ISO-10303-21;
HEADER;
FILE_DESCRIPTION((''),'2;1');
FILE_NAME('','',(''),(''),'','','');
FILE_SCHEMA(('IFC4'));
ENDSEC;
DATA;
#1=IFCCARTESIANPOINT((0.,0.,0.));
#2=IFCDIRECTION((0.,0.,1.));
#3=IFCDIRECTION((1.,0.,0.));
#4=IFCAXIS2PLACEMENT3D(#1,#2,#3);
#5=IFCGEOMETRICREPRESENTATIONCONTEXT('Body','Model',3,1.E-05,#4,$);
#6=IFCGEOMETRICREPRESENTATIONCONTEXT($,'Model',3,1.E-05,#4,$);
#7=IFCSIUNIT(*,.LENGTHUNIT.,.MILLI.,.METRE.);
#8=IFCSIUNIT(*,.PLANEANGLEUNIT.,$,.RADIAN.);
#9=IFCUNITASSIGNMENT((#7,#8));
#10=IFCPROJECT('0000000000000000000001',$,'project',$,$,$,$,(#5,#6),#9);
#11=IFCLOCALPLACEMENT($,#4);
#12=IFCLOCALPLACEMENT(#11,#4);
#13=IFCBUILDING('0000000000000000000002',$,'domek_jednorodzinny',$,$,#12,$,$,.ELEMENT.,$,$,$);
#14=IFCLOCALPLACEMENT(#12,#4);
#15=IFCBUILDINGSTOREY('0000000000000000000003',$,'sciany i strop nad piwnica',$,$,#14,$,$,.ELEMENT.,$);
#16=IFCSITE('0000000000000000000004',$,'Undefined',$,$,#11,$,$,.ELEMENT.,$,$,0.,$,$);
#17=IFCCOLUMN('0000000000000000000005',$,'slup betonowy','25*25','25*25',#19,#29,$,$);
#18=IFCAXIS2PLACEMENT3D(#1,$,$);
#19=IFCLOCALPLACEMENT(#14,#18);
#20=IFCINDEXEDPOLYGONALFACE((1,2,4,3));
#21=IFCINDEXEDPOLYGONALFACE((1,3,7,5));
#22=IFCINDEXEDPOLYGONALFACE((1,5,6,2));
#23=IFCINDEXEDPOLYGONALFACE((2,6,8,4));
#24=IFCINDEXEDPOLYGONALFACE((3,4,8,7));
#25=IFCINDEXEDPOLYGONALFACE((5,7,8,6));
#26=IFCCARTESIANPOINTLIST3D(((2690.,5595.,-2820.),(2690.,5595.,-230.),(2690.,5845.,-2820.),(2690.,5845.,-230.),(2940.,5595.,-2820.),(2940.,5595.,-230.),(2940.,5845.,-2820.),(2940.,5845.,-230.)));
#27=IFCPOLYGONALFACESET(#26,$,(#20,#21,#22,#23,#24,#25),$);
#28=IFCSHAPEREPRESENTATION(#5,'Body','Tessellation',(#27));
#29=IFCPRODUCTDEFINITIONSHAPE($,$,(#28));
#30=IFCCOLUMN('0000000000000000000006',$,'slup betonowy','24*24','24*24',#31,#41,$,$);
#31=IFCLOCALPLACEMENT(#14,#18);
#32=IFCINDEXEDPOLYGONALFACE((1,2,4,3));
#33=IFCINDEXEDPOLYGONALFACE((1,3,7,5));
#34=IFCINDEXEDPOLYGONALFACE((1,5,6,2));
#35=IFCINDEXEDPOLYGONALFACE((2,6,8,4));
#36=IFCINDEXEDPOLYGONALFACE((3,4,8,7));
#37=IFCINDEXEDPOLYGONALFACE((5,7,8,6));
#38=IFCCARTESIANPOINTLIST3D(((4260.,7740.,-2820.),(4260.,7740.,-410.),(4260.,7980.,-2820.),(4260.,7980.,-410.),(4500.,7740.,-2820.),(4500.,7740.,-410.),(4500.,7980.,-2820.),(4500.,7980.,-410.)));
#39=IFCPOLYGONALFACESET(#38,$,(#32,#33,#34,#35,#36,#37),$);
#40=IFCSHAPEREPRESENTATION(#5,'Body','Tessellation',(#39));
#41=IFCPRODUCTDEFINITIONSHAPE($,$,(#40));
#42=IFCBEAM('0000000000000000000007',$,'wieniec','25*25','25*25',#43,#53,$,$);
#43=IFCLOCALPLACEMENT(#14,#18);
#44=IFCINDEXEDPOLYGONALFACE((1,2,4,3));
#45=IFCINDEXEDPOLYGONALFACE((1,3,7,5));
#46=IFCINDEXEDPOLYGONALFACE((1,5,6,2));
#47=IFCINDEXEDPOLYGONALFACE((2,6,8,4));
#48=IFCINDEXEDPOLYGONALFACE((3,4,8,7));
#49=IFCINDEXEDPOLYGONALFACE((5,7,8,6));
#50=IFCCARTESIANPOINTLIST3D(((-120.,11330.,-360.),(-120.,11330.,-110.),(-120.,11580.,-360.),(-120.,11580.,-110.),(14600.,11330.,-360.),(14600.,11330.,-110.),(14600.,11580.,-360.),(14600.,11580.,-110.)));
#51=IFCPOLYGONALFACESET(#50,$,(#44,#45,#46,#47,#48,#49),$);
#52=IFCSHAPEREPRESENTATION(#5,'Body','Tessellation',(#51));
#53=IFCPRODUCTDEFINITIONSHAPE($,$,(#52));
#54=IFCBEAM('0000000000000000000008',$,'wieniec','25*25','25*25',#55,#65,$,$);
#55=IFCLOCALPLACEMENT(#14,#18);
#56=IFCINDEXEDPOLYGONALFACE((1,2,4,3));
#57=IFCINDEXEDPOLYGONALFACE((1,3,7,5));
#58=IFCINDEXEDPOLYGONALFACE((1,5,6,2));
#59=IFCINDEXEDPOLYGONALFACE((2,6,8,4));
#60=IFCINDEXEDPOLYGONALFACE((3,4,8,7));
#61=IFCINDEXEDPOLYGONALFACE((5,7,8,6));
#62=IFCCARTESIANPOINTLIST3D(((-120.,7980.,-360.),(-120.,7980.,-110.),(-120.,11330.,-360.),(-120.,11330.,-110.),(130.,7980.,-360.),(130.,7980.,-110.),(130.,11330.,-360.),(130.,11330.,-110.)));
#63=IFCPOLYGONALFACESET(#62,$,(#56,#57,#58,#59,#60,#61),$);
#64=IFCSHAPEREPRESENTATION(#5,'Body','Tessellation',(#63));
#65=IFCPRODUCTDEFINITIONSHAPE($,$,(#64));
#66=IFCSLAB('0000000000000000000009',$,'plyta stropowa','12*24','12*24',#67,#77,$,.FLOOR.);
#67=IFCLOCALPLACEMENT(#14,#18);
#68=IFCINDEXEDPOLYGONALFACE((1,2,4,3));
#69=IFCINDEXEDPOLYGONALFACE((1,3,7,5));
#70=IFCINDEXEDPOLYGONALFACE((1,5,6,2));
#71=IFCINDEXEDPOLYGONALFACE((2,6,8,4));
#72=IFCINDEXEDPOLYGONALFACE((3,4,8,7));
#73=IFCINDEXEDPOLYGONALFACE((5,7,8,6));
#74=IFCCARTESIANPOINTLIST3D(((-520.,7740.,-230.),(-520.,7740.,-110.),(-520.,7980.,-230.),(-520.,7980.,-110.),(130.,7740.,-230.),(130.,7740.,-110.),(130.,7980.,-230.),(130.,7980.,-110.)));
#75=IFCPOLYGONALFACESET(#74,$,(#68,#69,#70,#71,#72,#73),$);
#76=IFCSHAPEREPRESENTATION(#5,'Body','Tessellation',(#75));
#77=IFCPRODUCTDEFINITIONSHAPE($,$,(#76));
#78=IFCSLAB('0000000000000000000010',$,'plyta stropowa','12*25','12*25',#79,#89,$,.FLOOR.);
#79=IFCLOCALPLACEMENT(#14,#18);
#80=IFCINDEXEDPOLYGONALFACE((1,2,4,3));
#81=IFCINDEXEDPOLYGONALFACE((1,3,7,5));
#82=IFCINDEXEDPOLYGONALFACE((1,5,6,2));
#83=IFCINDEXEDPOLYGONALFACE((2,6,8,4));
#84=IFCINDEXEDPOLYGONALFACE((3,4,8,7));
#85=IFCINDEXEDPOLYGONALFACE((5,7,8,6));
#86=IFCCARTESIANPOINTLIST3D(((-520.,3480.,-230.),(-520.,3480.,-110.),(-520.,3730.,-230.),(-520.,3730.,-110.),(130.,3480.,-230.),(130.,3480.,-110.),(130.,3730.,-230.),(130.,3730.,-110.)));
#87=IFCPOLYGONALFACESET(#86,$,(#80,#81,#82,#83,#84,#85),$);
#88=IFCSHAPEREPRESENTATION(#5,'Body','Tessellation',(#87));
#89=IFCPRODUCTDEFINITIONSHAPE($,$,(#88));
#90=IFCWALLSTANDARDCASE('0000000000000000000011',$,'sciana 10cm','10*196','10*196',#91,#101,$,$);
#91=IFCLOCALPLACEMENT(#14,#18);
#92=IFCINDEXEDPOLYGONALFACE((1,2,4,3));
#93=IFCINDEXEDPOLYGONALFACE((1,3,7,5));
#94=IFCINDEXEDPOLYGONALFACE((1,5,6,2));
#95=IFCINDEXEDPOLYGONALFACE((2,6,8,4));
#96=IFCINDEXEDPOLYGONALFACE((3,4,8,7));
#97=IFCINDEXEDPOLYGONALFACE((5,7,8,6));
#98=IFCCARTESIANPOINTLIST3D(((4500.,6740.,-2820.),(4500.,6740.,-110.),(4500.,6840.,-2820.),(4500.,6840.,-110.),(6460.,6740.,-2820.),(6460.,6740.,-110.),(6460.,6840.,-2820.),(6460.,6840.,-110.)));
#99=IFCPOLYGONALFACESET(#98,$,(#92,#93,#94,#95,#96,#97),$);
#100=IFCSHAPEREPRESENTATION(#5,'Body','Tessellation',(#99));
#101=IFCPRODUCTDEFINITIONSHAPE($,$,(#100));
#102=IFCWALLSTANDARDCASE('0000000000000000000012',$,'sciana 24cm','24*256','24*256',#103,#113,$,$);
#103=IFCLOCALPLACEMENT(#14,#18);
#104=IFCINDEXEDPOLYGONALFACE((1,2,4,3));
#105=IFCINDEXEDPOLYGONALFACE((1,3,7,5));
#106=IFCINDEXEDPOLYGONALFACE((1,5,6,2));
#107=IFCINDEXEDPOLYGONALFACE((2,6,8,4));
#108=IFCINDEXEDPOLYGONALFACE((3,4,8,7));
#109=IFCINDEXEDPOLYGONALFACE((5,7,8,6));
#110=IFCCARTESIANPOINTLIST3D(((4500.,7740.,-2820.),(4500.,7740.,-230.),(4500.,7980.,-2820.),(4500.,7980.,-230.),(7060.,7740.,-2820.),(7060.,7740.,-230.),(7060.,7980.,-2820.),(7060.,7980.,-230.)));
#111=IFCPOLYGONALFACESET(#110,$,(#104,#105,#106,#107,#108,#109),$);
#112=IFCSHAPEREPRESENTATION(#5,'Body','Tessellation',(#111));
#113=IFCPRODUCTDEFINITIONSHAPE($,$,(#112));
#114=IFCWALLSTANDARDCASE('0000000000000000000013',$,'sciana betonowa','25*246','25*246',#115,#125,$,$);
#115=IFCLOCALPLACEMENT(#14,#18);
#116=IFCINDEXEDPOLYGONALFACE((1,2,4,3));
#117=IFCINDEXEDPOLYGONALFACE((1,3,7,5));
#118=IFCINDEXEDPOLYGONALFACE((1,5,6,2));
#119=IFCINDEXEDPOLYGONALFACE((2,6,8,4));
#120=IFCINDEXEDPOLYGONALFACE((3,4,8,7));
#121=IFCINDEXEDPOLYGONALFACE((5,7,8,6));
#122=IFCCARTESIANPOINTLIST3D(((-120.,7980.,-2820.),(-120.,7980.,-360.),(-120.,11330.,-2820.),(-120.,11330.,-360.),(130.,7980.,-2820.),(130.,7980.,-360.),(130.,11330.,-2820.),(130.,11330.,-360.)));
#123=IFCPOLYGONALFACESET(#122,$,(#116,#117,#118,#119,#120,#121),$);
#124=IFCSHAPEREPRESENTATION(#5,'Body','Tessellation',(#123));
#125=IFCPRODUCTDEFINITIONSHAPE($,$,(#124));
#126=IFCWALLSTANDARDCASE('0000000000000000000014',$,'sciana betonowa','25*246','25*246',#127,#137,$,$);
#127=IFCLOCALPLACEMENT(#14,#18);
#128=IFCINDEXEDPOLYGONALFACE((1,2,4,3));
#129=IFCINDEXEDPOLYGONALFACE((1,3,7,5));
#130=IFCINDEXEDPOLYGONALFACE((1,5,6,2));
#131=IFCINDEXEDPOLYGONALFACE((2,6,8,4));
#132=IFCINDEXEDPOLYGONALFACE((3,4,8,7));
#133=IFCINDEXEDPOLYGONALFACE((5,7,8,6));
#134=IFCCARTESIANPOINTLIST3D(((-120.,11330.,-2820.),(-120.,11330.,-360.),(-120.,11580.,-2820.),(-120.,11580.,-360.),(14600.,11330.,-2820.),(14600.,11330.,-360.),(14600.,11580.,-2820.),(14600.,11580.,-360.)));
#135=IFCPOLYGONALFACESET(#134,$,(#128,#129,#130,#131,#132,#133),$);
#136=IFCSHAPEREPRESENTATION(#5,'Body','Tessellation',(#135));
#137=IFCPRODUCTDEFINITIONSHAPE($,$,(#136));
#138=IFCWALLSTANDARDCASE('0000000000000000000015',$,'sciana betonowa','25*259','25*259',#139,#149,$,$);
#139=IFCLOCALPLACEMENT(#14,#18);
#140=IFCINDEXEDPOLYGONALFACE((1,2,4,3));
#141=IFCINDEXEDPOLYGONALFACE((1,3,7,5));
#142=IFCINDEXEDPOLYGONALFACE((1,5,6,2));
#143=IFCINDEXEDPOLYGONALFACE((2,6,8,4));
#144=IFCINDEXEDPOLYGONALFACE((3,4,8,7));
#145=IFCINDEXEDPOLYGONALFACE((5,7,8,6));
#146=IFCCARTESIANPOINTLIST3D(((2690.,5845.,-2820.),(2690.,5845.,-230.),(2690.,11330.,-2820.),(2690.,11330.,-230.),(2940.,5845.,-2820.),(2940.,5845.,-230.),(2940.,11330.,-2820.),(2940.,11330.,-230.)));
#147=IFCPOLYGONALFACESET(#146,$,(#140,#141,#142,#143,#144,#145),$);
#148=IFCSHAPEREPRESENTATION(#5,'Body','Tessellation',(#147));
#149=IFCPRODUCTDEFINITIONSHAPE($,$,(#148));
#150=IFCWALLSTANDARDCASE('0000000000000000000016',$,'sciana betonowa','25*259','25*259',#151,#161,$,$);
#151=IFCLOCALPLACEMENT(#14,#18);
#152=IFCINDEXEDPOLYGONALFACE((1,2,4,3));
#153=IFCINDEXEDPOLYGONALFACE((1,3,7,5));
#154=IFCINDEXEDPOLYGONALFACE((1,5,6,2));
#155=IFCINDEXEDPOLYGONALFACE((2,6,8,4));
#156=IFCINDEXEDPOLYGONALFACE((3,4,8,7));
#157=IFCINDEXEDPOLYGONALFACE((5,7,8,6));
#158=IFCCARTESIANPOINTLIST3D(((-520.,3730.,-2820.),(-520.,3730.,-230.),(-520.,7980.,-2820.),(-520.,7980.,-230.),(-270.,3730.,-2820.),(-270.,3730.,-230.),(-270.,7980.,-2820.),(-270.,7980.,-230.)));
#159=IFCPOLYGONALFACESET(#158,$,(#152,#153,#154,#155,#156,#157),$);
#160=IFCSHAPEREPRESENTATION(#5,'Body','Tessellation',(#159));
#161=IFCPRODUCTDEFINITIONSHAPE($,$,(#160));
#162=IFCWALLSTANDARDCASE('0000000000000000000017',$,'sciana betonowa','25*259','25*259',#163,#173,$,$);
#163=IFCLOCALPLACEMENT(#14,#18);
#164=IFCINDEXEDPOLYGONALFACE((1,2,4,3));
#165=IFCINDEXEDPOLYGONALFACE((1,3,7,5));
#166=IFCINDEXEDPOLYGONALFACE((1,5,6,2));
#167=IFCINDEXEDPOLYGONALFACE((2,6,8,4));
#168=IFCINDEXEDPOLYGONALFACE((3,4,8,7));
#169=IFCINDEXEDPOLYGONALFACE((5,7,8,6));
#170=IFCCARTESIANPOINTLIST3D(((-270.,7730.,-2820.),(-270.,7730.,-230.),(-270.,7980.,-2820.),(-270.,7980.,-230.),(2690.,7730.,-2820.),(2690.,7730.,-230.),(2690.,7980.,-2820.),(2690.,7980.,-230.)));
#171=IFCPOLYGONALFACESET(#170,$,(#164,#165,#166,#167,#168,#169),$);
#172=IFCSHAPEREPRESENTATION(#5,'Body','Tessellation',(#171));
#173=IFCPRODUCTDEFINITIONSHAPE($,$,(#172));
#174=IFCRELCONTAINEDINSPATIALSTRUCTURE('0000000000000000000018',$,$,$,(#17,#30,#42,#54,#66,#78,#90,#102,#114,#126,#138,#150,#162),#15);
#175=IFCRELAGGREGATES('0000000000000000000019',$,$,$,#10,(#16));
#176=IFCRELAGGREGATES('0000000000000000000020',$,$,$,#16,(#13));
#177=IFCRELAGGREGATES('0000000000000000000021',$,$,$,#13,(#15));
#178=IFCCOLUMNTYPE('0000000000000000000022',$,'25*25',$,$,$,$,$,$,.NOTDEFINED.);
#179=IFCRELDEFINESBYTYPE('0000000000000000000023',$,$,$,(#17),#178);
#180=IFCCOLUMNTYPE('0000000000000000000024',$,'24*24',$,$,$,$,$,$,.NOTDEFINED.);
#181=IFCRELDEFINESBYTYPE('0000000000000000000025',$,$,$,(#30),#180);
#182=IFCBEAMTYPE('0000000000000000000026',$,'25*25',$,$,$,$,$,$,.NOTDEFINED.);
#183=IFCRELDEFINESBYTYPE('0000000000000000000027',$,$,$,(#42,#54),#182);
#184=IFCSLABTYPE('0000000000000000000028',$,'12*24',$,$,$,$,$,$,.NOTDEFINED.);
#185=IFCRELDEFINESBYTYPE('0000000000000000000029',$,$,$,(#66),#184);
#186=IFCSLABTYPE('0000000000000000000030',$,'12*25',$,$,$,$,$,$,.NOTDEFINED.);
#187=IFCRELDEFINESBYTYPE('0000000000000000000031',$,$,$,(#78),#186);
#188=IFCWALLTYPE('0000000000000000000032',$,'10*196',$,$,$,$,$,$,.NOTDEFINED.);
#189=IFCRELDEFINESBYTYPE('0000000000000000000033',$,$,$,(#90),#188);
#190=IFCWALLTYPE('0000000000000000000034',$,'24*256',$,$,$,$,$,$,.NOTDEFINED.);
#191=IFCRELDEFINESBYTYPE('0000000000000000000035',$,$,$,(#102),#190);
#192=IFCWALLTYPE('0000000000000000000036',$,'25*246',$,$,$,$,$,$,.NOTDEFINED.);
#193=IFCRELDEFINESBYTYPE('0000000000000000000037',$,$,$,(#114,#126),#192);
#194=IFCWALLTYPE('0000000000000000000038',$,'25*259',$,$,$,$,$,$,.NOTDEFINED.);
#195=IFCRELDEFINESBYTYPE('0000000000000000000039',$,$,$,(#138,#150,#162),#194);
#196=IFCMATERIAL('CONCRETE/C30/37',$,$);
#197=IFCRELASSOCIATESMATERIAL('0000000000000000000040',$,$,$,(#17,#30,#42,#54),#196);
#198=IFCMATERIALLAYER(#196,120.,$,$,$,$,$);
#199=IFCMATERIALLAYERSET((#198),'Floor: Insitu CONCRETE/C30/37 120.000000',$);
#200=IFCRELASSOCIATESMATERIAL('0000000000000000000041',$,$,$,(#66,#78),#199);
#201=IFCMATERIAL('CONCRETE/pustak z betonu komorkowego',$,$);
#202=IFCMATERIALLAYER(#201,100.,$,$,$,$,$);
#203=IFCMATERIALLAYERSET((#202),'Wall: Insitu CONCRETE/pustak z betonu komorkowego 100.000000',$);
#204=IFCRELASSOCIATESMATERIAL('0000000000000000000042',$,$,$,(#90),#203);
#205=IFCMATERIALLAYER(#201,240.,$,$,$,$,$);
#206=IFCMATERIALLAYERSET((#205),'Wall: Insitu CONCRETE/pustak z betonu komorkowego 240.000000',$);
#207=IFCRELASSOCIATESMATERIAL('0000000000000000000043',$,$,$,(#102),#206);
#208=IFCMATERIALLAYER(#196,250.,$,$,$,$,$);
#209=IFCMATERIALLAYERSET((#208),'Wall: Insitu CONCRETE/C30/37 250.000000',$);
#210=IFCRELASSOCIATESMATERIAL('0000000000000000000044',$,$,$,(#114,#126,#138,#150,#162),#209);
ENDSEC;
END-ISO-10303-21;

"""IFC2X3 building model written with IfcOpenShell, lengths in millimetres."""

from ifc_helpers import new_model, si_unit, frame, frame_2d, origin_with_axes, origin_2d_with_axis, place, context, project, spatial, polyline, rectangle, outline, extrude, material, layer, layer_set, layer_usage, type_object, element, save


model = new_model("IFC2X3")

# Units and contexts
model_context_1 = context("Model", 3, precision=1e-05, world=origin_with_axes(), identifier="Body")
model_context_2 = context("Model", 3, precision=1e-05, world=origin_with_axes())
ifc_project = project(units=[si_unit("LENGTHUNIT", "METRE", prefix="MILLI"), si_unit("PLANEANGLEUNIT", "RADIAN")], contexts=[model_context_1, model_context_2])

# Site, building, storey
site_placement = place(None, origin_with_axes())
site = spatial("IfcSite", under=ifc_project, at=site_placement, Name="Undefined", CompositionType="ELEMENT", RefElevation=0.0)
building_placement = place(site_placement, origin_with_axes())
building = spatial("IfcBuilding", under=site, at=building_placement, Name="domek_jednorodzinny", CompositionType="ELEMENT")
storey_placement = place(building_placement, origin_with_axes())
storey = spatial("IfcBuildingStorey", under=building, at=storey_placement, Name="sciany i strop nad piwnica", CompositionType="ELEMENT")

# Columns
ifc_material_1 = material(Name="CONCRETE/C30/37")
column_type_1 = type_object("IfcColumnType", Name="25*25", PredefinedType="NOTDEFINED")
column_1_placement = place(storey_placement, frame((2815.0, 5720.0, -2820.0), z_axis=(0.0, 0.0, 1.0), x_axis=(1.0, 0.0, 0.0)))
element("IfcColumn", 1, at=column_1_placement, inside=storey, type_object=column_type_1, material=ifc_material_1, Name="slup betonowy", Description="25*25", ObjectType="25*25", context=model_context_1, shape_type="SweptSolid", body=[
    extrude(rectangle(XDim=250.0, YDim=250.0, at=origin_2d_with_axis()), frame((0.0, 0.0, 2590.0), z_axis=(-0.000012, 0.000012, -1.0), x_axis=(-1.0, 0.0, 0.000012)), (0.0, 0.0, 1.0), 2590.0),
])
column_type_2 = type_object("IfcColumnType", Name="24*24", PredefinedType="NOTDEFINED")
column_2_placement = place(storey_placement, frame((4380.0, 7860.0, -2820.0), z_axis=(0.0, 0.0, 1.0), x_axis=(1.0, 0.0, 0.0)))
element("IfcColumn", 2, at=column_2_placement, inside=storey, type_object=column_type_2, material=ifc_material_1, Name="slup betonowy", Description="24*24", ObjectType="24*24", context=model_context_1, shape_type="SweptSolid", body=[
    extrude(rectangle(XDim=240.0, YDim=240.0, at=origin_2d_with_axis()), frame((0.0, 0.0, 2410.0), z_axis=(0.000001, 0.000001, -1.0), x_axis=(-1.0, 0.0, 0.0)), (0.0, 0.0, 1.0), 2410.0),
])

# Beams
beam_type_1 = type_object("IfcBeamType", Name="25*25", PredefinedType="NOTDEFINED")
beam_1_placement = place(storey_placement, frame((-120.0, 11455.0, -235.0), z_axis=(0.0, 0.0, 1.0), x_axis=(1.0, 0.0, 0.0)))
element("IfcBeam", 3, at=beam_1_placement, inside=storey, type_object=beam_type_1, material=ifc_material_1, Name="wieniec", Description="25*25", ObjectType="25*25", context=model_context_1, shape_type="SweptSolid", body=[
    extrude(rectangle(XDim=250.0, YDim=250.0, at=origin_2d_with_axis()), frame((14720.0, 0.0, 0.0), z_axis=(-1.0, 0.0, 0.0), x_axis=(0.0, -1.0, 0.0)), (0.0, 0.0, 1.0), 14720.0),
])
beam_2_placement = place(storey_placement, frame((5.0, 7980.0, -235.0), z_axis=(0.0, 0.0, 1.0), x_axis=(0.0, 1.0, 0.0)))
element("IfcBeam", 4, at=beam_2_placement, inside=storey, type_object=beam_type_1, material=ifc_material_1, Name="wieniec", Description="25*25", ObjectType="25*25", context=model_context_1, shape_type="SweptSolid", body=[
    extrude(rectangle(XDim=250.0, YDim=250.0, at=origin_2d_with_axis()), frame((3350.0, 0.0, 0.0), z_axis=(-1.0, 0.0, 0.0), x_axis=(0.0, -1.0, 0.0)), (0.0, 0.0, 1.0), 3350.0),
])

# Shared definitions
ifc_layer_1 = layer(ifc_material_1, 120.0)
ifc_layer_set_1 = layer_set([ifc_layer_1], Name="Floor: Insitu CONCRETE/C30/37 120.000000")

# Slabs
ifc_layer_usage_1 = layer_usage(ifc_layer_set_1, "AXIS3", "POSITIVE", -60.0)
slab_type_1 = type_object("IfcSlabType", Name="12*24", PredefinedType="NOTDEFINED")
slab_1_placement = place(storey_placement, frame((130.0, 7980.0, -170.0), z_axis=(0.0, 0.0, 1.0), x_axis=(-1.0, 0.0, 0.0)))
element("IfcSlab", 5, at=slab_1_placement, inside=storey, type_object=slab_type_1, material=ifc_layer_usage_1, Name="plyta stropowa", Description="12*24", ObjectType="12*24", PredefinedType="FLOOR", context=model_context_1, shape_type="SweptSolid", body=[
    extrude(outline(polyline([(0.0, 0.0), (650.0, 0.0), (650.0, 240.0), (0.0, 240.0), (0.0, 0.0)])), frame((0.0, 0.0, -60.0), z_axis=(0.0, 0.0, 1.0), x_axis=(1.0, 0.0, 0.0)), (0.0, 0.0, 1.0), 120.0),
])
ifc_layer_usage_2 = layer_usage(ifc_layer_set_1, "AXIS3", "POSITIVE", -60.0)
slab_type_2 = type_object("IfcSlabType", Name="12*25", PredefinedType="NOTDEFINED")
slab_2_placement = place(storey_placement, frame((130.0, 3730.0, -170.0), z_axis=(0.0, 0.0, 1.0), x_axis=(-1.0, 0.0, 0.0)))
element("IfcSlab", 6, at=slab_2_placement, inside=storey, type_object=slab_type_2, material=ifc_layer_usage_2, Name="plyta stropowa", Description="12*25", ObjectType="12*25", PredefinedType="FLOOR", context=model_context_1, shape_type="SweptSolid", body=[
    extrude(outline(polyline([(0.0, 0.0), (650.0, 0.0), (650.0, 250.0), (0.0, 250.0), (0.0, 0.0)])), frame((0.0, 0.0, -60.0), z_axis=(0.0, 0.0, 1.0), x_axis=(1.0, 0.0, 0.0)), (0.0, 0.0, 1.0), 120.0),
])

# Walls
ifc_material_2 = material(Name="CONCRETE/pustak z betonu komorkowego")
ifc_layer_2 = layer(ifc_material_2, 100.0)
ifc_layer_set_2 = layer_set([ifc_layer_2], Name="Wall: Insitu CONCRETE/pustak z betonu komorkowego 100.000000")
ifc_layer_usage_3 = layer_usage(ifc_layer_set_2, "AXIS2", "POSITIVE", -50.0)
wall_type_1 = type_object("IfcWallType", Name="10*196", PredefinedType="NOTDEFINED")
wall_1_placement = place(storey_placement, frame((4500.0, 6790.0, -2820.0), z_axis=(0.0, 0.0, 1.0), x_axis=(1.0, 0.0, 0.0)))
element("IfcWallStandardCase", 7, at=wall_1_placement, inside=storey, type_object=wall_type_1, material=ifc_layer_usage_3, Name="sciana 10cm", Description="10*196", ObjectType="10*196", context=model_context_1, shape_type="SweptSolid", body=[
    extrude(rectangle(XDim=1960.0, YDim=100.0, at=frame_2d((0.0, 980.0), x_axis=(0.0, -1.0))), frame((0.0, 0.0, 0.0), z_axis=(0.0, 0.0, 1.0), x_axis=(0.0, -1.0, 0.0)), (0.0, 0.0, 1.0), 2710.0),
])
ifc_layer_3 = layer(ifc_material_2, 240.0)
ifc_layer_set_3 = layer_set([ifc_layer_3], Name="Wall: Insitu CONCRETE/pustak z betonu komorkowego 240.000000")
ifc_layer_usage_4 = layer_usage(ifc_layer_set_3, "AXIS2", "POSITIVE", -120.0)
wall_type_2 = type_object("IfcWallType", Name="24*256", PredefinedType="NOTDEFINED")
wall_2_placement = place(storey_placement, frame((4500.0, 7860.0, -2820.0), z_axis=(0.0, 0.0, 1.0), x_axis=(1.0, 0.0, 0.0)))
element("IfcWallStandardCase", 8, at=wall_2_placement, inside=storey, type_object=wall_type_2, material=ifc_layer_usage_4, Name="sciana 24cm", Description="24*256", ObjectType="24*256", context=model_context_1, shape_type="SweptSolid", body=[
    extrude(rectangle(XDim=2560.0, YDim=240.0, at=frame_2d((0.0, 1280.0), x_axis=(0.0, -1.0))), frame((0.0, 0.0, 0.0), z_axis=(0.0, 0.0, 1.0), x_axis=(0.0, -1.0, 0.0)), (0.0, 0.0, 1.0), 2590.0),
])
ifc_layer_4 = layer(ifc_material_1, 250.0)
ifc_layer_set_4 = layer_set([ifc_layer_4], Name="Wall: Insitu CONCRETE/C30/37 250.000000")
ifc_layer_usage_5 = layer_usage(ifc_layer_set_4, "AXIS2", "POSITIVE", -125.0)
wall_type_3 = type_object("IfcWallType", Name="25*246", PredefinedType="NOTDEFINED")
wall_3_placement = place(storey_placement, frame((5.0, 7980.0, -2820.0), z_axis=(0.0, 0.0, 1.0), x_axis=(0.0, 1.0, 0.0)))
element("IfcWallStandardCase", 9, at=wall_3_placement, inside=storey, type_object=wall_type_3, material=ifc_layer_usage_5, Name="sciana betonowa", Description="25*246", ObjectType="25*246", context=model_context_1, shape_type="SweptSolid", body=[
    extrude(rectangle(XDim=3350.0, YDim=250.0, at=frame_2d((0.0, 1675.0), x_axis=(0.0, -1.0))), frame((0.0, 0.0, 0.0), z_axis=(0.0, 0.0, 1.0), x_axis=(0.0, -1.0, 0.0)), (0.0, 0.0, 1.0), 2460.0),
])
ifc_layer_usage_6 = layer_usage(ifc_layer_set_4, "AXIS2", "POSITIVE", -125.0)
wall_4_placement = place(storey_placement, frame((-120.0, 11455.0, -2820.0), z_axis=(0.0, 0.0, 1.0), x_axis=(1.0, 0.0, 0.0)))
element("IfcWallStandardCase", 10, at=wall_4_placement, inside=storey, type_object=wall_type_3, material=ifc_layer_usage_6, Name="sciana betonowa", Description="25*246", ObjectType="25*246", context=model_context_1, shape_type="SweptSolid", body=[
    extrude(rectangle(XDim=14720.0, YDim=250.0, at=frame_2d((0.0, 7360.0), x_axis=(0.0, -1.0))), frame((0.0, 0.0, 0.0), z_axis=(0.0, 0.0, 1.0), x_axis=(0.0, -1.0, 0.0)), (0.0, 0.0, 1.0), 2460.0),
])
ifc_layer_usage_7 = layer_usage(ifc_layer_set_4, "AXIS2", "POSITIVE", -125.0)
wall_type_4 = type_object("IfcWallType", Name="25*259", PredefinedType="NOTDEFINED")
wall_5_placement = place(storey_placement, frame((2815.0, 5845.0, -2820.0), z_axis=(0.0, 0.0, 1.0), x_axis=(0.0, 1.0, 0.0)))
element("IfcWallStandardCase", 11, at=wall_5_placement, inside=storey, type_object=wall_type_4, material=ifc_layer_usage_7, Name="sciana betonowa", Description="25*259", ObjectType="25*259", context=model_context_1, shape_type="SweptSolid", body=[
    extrude(rectangle(XDim=5485.0, YDim=250.0, at=frame_2d((0.0, 2742.5), x_axis=(0.0, -1.0))), frame((0.0, 0.0, 0.0), z_axis=(0.0, 0.0, 1.0), x_axis=(0.0, -1.0, 0.0)), (0.0, 0.0, 1.0), 2590.0),
])
ifc_layer_usage_8 = layer_usage(ifc_layer_set_4, "AXIS2", "POSITIVE", -125.0)
wall_6_placement = place(storey_placement, frame((-395.0, 3730.0, -2820.0), z_axis=(0.0, 0.0, 1.0), x_axis=(0.0, 1.0, 0.0)))
element("IfcWallStandardCase", 12, at=wall_6_placement, inside=storey, type_object=wall_type_4, material=ifc_layer_usage_8, Name="sciana betonowa", Description="25*259", ObjectType="25*259", context=model_context_1, shape_type="SweptSolid", body=[
    extrude(rectangle(XDim=4250.0, YDim=250.0, at=frame_2d((0.0, 2125.0), x_axis=(0.0, -1.0))), frame((0.0, 0.0, 0.0), z_axis=(0.0, 0.0, 1.0), x_axis=(0.0, -1.0, 0.0)), (0.0, 0.0, 1.0), 2590.0),
])
ifc_layer_usage_9 = layer_usage(ifc_layer_set_4, "AXIS2", "POSITIVE", -125.0)
wall_7_placement = place(storey_placement, frame((-270.0, 7855.0, -2820.0), z_axis=(0.0, 0.0, 1.0), x_axis=(1.0, 0.0, 0.0)))
element("IfcWallStandardCase", 13, at=wall_7_placement, inside=storey, type_object=wall_type_4, material=ifc_layer_usage_9, Name="sciana betonowa", Description="25*259", ObjectType="25*259", context=model_context_1, shape_type="SweptSolid", body=[
    extrude(rectangle(XDim=2960.0, YDim=250.0, at=frame_2d((0.0, 1480.0), x_axis=(0.0, -1.0))), frame((0.0, 0.0, 0.0), z_axis=(0.0, 0.0, 1.0), x_axis=(0.0, -1.0, 0.0)), (0.0, 0.0, 1.0), 2590.0),
])

save(model, "model.ifc")
